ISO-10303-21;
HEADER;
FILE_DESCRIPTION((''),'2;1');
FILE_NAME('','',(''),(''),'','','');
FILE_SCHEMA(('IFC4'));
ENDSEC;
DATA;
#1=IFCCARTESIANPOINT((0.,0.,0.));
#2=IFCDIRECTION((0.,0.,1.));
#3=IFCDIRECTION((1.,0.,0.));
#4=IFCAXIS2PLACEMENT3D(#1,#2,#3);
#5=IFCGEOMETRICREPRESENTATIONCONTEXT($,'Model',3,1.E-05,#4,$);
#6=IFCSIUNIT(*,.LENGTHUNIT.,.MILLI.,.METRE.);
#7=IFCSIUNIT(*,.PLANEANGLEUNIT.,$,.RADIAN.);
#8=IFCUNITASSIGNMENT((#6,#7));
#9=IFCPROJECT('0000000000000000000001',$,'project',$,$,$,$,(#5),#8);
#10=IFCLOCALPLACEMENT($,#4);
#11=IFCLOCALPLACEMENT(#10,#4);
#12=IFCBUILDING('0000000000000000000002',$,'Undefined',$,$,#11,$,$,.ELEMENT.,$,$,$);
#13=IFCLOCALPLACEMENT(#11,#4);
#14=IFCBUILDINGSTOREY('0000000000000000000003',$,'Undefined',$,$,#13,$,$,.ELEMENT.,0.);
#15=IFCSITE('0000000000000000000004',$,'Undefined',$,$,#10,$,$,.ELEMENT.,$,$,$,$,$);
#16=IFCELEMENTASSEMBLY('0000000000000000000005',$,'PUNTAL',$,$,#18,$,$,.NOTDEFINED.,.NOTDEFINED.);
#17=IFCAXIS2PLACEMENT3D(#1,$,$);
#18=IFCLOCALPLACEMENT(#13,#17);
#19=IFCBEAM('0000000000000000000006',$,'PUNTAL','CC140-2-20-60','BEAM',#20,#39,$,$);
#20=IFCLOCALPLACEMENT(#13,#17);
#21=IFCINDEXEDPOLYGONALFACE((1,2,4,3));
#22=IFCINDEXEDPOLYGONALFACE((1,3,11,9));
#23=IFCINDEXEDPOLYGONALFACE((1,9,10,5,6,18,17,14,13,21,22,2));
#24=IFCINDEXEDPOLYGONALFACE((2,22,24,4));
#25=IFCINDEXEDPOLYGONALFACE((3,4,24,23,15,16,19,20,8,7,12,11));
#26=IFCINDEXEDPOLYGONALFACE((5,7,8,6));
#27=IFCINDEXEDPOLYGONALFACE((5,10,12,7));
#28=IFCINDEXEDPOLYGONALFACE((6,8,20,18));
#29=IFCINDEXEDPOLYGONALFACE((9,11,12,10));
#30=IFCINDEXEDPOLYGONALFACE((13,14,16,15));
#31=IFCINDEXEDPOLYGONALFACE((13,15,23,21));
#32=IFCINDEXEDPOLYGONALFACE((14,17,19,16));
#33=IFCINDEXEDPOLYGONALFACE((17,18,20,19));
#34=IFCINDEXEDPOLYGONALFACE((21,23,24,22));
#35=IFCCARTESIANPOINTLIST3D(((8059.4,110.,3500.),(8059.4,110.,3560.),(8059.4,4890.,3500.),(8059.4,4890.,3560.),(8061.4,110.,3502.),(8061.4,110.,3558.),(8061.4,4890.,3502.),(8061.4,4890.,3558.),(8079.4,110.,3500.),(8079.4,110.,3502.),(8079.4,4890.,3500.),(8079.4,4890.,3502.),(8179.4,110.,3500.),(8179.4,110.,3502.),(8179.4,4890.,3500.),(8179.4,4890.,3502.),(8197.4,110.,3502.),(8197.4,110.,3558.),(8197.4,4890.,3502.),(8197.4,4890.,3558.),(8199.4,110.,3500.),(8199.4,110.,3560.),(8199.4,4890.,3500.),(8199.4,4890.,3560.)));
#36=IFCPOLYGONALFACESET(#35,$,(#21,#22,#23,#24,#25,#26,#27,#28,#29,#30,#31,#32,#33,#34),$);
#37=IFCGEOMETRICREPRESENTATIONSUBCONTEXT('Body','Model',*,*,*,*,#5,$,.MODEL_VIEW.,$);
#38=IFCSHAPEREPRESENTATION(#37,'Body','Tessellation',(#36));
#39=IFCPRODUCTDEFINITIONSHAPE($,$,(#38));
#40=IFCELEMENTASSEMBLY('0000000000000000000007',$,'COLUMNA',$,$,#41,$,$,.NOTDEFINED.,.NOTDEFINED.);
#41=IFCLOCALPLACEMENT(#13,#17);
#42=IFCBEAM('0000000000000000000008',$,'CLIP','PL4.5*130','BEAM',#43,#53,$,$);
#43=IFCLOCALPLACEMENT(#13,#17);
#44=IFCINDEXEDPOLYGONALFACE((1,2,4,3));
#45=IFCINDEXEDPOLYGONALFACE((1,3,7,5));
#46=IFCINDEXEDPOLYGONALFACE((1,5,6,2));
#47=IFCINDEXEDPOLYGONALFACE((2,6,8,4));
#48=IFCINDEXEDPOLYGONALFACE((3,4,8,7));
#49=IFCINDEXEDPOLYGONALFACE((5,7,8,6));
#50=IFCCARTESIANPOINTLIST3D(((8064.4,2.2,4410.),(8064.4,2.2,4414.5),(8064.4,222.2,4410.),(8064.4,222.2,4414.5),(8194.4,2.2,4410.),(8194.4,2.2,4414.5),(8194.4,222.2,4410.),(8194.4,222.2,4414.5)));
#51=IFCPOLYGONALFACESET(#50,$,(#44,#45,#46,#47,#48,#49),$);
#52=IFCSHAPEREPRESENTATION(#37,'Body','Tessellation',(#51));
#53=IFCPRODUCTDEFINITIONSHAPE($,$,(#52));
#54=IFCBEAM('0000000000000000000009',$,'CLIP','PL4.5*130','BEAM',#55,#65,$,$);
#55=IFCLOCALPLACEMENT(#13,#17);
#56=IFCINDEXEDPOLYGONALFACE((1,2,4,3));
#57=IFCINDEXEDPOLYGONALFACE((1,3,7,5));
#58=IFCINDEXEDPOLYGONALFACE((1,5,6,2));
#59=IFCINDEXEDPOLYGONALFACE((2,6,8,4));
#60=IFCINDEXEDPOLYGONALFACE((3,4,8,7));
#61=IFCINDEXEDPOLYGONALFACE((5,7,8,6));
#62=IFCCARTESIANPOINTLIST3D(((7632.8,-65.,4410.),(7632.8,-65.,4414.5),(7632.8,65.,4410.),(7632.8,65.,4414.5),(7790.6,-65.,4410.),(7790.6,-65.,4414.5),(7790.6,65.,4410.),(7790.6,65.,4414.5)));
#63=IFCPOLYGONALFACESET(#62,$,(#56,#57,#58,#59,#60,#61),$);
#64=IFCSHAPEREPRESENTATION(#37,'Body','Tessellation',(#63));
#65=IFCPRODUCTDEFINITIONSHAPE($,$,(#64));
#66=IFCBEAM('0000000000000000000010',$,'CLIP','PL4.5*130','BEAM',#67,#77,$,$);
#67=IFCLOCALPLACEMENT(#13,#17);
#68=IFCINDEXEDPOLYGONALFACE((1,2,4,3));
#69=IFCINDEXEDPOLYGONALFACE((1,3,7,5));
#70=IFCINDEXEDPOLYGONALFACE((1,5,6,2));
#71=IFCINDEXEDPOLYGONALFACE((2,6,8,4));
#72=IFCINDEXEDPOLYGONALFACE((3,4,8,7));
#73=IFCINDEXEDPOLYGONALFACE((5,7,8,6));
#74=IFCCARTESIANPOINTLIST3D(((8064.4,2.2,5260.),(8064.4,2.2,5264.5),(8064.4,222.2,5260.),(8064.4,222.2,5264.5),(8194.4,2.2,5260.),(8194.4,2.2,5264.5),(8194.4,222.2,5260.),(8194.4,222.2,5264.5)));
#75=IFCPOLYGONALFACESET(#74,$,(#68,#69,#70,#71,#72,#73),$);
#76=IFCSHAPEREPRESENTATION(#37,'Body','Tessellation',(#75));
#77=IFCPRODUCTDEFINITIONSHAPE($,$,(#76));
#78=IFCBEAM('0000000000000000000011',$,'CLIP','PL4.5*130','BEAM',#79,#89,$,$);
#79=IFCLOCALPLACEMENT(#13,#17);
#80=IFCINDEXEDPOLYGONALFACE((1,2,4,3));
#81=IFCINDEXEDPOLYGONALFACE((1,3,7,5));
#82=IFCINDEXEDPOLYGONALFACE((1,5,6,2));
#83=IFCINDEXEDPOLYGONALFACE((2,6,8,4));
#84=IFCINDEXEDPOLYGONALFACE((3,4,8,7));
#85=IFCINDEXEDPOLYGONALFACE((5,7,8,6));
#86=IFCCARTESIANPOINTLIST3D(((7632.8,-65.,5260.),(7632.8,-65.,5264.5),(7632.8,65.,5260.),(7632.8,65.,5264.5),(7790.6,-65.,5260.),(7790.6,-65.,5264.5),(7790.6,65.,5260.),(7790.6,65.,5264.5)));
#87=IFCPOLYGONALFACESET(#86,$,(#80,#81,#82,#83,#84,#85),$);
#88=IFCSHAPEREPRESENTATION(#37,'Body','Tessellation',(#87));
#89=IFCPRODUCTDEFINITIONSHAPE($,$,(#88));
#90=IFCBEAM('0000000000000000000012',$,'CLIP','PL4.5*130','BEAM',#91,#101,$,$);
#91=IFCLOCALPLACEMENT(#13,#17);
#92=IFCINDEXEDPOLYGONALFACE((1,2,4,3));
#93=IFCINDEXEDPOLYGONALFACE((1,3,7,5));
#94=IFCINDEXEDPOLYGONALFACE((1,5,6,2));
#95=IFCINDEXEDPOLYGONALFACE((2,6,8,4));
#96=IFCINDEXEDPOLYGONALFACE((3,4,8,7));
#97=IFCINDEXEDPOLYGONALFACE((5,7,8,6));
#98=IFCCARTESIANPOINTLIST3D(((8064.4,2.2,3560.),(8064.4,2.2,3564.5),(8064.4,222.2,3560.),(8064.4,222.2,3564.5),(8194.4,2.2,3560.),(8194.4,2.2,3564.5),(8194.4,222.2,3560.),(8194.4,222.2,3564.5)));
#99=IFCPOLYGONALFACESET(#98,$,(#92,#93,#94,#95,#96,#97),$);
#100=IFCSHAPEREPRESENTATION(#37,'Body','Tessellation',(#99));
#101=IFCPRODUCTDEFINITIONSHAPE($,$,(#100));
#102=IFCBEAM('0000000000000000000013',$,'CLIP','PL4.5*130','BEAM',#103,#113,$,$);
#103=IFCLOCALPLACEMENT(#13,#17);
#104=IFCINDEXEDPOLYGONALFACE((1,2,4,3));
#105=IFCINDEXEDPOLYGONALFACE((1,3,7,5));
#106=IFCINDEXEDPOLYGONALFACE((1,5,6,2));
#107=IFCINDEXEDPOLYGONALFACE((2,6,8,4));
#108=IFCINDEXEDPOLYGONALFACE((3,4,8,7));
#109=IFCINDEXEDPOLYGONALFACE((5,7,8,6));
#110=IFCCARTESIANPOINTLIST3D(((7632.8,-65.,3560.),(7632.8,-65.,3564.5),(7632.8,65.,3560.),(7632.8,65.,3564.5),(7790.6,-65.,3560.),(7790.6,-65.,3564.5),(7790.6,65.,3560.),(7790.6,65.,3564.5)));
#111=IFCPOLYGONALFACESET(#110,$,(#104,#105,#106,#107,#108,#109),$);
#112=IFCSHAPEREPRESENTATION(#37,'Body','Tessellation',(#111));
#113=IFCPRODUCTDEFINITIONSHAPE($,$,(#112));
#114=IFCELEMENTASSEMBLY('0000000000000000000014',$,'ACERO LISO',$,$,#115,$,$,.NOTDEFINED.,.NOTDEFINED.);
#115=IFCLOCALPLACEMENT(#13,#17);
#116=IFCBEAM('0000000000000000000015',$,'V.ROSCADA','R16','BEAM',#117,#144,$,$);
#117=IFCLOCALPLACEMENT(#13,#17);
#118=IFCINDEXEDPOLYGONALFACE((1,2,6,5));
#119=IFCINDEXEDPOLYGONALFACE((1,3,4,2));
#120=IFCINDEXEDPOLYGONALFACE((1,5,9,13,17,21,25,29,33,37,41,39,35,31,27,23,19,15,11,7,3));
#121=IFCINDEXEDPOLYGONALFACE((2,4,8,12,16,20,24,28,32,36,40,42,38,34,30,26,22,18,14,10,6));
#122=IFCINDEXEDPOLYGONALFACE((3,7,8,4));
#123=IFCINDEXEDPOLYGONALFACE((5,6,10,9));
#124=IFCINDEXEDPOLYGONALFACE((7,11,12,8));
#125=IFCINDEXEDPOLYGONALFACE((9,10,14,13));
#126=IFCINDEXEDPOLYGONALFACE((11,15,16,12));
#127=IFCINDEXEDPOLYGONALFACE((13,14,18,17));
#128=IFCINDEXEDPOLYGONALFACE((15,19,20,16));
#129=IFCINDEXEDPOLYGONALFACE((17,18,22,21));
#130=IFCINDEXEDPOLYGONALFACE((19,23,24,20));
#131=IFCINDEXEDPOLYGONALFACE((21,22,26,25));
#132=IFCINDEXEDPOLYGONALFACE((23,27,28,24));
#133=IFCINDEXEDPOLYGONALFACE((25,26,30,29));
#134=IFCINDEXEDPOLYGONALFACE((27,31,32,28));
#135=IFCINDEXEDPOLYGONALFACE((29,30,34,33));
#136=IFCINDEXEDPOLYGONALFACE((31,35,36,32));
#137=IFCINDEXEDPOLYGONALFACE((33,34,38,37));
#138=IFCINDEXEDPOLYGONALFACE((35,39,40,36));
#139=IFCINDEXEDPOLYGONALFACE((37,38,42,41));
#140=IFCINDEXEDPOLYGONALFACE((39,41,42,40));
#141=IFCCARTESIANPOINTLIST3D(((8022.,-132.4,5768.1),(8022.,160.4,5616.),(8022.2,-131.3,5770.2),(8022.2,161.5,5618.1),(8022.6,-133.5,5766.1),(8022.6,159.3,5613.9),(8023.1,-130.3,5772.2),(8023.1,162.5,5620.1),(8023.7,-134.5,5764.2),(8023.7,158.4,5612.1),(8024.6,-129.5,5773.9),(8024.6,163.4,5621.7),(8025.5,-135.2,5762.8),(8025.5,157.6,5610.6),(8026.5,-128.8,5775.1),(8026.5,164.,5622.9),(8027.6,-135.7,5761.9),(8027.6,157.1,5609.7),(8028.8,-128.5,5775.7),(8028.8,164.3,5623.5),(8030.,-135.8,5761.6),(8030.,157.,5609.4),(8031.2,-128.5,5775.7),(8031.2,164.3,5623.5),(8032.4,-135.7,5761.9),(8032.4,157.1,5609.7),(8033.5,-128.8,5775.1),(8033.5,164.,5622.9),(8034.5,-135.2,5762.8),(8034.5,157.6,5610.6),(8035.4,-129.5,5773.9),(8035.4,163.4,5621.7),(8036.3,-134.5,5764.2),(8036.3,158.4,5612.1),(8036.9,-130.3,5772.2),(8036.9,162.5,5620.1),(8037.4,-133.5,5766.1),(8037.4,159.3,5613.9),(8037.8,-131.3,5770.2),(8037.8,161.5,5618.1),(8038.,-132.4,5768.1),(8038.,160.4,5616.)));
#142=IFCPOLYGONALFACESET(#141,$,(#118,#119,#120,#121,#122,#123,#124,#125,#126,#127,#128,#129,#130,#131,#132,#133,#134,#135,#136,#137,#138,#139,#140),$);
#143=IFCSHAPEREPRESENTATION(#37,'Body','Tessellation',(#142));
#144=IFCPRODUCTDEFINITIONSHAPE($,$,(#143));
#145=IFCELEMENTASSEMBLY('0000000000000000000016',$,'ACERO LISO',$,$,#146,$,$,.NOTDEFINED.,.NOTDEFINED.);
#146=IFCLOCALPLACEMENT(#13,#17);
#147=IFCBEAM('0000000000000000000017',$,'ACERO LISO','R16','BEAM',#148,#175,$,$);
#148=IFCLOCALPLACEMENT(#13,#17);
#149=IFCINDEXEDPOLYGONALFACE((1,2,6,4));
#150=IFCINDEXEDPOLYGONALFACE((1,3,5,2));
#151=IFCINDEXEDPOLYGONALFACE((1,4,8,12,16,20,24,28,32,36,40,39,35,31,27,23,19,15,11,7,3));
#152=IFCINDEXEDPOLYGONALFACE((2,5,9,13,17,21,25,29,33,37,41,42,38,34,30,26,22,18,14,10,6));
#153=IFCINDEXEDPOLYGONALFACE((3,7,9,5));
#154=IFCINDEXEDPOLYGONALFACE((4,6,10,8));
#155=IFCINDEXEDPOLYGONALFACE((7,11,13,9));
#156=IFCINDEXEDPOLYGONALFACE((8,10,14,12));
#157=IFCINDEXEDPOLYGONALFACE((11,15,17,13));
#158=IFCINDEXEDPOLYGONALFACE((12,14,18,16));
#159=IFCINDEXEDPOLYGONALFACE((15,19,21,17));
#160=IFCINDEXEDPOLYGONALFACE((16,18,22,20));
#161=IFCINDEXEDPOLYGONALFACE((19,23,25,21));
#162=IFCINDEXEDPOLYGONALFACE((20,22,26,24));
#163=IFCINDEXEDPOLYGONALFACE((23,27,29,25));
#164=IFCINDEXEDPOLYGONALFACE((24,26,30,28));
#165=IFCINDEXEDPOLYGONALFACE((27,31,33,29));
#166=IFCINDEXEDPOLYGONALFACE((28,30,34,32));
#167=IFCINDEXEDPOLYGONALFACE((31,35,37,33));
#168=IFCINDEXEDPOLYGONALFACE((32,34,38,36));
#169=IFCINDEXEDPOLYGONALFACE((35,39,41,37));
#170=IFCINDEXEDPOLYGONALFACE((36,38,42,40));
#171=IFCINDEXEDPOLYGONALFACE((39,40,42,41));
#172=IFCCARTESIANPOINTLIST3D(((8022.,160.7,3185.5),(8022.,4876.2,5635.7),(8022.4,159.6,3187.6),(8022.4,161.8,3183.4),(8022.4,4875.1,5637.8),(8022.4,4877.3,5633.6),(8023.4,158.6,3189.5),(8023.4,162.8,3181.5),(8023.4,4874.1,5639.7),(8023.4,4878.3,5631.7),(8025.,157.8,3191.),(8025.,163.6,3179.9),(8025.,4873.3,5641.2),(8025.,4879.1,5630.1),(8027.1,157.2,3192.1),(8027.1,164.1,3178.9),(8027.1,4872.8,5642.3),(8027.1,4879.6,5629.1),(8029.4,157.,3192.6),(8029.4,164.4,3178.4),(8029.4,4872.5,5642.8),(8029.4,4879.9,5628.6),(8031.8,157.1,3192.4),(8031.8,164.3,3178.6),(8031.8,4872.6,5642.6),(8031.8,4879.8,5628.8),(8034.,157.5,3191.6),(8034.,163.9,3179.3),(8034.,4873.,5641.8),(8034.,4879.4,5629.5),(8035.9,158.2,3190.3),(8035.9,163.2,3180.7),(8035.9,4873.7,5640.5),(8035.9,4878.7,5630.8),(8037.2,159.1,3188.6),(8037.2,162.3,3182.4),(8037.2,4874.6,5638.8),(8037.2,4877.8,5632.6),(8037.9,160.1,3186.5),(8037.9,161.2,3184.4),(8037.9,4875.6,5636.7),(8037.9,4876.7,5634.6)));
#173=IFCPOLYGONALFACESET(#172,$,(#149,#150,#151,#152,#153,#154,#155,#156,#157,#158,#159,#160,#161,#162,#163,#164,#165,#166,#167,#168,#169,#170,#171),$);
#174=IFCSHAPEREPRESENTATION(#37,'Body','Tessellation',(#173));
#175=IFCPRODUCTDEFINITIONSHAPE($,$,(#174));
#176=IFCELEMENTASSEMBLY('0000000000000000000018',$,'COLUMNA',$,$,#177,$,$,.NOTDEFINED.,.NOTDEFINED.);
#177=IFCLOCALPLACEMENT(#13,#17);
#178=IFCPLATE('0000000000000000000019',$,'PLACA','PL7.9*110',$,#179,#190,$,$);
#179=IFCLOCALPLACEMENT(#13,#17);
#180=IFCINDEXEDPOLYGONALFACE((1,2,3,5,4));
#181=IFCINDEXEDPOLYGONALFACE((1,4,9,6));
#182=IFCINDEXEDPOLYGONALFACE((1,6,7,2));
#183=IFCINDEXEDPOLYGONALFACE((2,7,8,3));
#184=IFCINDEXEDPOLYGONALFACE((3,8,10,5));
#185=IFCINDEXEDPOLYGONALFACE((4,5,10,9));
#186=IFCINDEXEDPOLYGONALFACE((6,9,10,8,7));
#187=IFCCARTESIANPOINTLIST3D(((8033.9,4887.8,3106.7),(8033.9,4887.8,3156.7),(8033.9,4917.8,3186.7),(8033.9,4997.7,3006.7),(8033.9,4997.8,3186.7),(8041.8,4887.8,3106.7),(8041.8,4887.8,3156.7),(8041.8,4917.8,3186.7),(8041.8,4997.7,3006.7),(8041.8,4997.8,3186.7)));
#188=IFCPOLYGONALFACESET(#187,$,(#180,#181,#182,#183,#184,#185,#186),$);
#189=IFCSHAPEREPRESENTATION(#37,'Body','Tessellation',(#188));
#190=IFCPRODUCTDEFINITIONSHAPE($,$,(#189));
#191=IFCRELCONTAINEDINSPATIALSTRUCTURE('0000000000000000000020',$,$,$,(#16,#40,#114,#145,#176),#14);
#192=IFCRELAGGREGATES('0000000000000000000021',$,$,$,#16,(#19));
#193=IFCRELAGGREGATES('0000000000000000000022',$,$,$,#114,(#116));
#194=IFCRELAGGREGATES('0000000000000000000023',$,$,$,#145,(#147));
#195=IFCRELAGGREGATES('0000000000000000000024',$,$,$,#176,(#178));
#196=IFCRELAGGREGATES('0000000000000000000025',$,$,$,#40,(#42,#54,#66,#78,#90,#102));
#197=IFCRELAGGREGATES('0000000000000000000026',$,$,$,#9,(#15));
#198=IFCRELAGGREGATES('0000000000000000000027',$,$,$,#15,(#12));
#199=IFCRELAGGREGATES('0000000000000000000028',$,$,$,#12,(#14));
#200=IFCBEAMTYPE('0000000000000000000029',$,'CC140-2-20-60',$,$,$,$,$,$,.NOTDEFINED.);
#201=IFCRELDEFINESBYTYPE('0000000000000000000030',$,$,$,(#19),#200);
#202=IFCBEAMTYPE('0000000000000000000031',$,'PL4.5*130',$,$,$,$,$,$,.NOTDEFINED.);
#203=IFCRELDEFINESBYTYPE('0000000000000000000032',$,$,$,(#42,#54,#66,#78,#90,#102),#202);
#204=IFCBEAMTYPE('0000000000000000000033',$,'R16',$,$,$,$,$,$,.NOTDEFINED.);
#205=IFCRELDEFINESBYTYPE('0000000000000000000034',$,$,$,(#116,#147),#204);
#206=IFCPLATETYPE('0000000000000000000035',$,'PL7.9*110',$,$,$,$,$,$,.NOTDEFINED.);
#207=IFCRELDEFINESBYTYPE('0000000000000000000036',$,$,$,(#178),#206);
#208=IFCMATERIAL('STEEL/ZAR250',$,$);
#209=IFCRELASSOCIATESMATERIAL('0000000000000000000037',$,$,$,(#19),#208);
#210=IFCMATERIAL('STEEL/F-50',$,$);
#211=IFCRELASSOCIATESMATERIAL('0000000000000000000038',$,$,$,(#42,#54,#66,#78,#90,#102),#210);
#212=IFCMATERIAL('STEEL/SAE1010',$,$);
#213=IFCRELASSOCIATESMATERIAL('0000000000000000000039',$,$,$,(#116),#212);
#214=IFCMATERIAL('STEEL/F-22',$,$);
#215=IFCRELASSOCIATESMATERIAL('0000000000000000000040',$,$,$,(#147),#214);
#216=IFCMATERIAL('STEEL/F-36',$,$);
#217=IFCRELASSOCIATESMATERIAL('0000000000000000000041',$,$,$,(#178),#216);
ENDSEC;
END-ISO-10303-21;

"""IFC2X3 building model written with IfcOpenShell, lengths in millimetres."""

from ifc_helpers import new_model, si_unit, frame, origin_with_axes, origin_2d_with_axis, place, context, subcontext, project, spatial, polyline, rectangle, circle, c_section, outline, extrude, clip, halfspace, material, type_object, element, aggregate, save


model = new_model("IFC2X3")

# Units and contexts
model_context = context("Model", 3, precision=1e-05, world=origin_with_axes())
body_context = subcontext(model_context, "Body", "Model", "MODEL_VIEW")
ifc_project = project(units=[si_unit("LENGTHUNIT", "METRE", prefix="MILLI"), si_unit("PLANEANGLEUNIT", "RADIAN")], contexts=[model_context])

# Site, building, storey
site_placement = place(None, origin_with_axes())
site = spatial("IfcSite", under=ifc_project, at=site_placement, Name="Undefined", CompositionType="ELEMENT")
building_placement = place(site_placement, origin_with_axes())
building = spatial("IfcBuilding", under=site, at=building_placement, Name="Undefined", CompositionType="ELEMENT")
storey_placement = place(building_placement, origin_with_axes())
storey = spatial("IfcBuildingStorey", under=building, at=storey_placement, Name="Undefined", CompositionType="ELEMENT", Elevation=0.0)

# Element assembly, beam
assembly_1_placement = place(storey_placement, origin_with_axes())
assembly_1 = element("IfcElementAssembly", 1, at=assembly_1_placement, inside=storey, Name="PUNTAL", AssemblyPlace="NOTDEFINED", PredefinedType="NOTDEFINED")
ifc_material_1 = material(Name="STEEL/ZAR250")
beam_type_1 = type_object("IfcBeamType", Name="CC140-2-20-60", PredefinedType="NOTDEFINED")
beam_1_placement = place(assembly_1_placement, frame((8129.4, 4890.0, 3530.0), z_axis=(-1.0, 0.0, 0.0), x_axis=(0.0, -1.0, 0.0)))
beam_1 = element("IfcBeam", 2, at=beam_1_placement, type_object=beam_type_1, material=ifc_material_1, Name="PUNTAL", Description="CC140-2-20-60", ObjectType="BEAM", context=body_context, shape_type="SweptSolid", body=[
    extrude(c_section(Depth=140.0, Width=60.0, WallThickness=2.0, Girth=20.0, at=origin_2d_with_axis()), frame((4780.0, 0.0, 0.0), z_axis=(-1.0, 0.0, 0.0), x_axis=(0.0, -1.0, 0.0)), (0.0, 0.0, 1.0), 4780.0),
])
aggregate(assembly_1, [beam_1])

# Element assembly, beams
assembly_2_placement = place(storey_placement, origin_with_axes())
assembly_2 = element("IfcElementAssembly", 3, at=assembly_2_placement, inside=storey, Name="COLUMNA", AssemblyPlace="NOTDEFINED", PredefinedType="NOTDEFINED")
ifc_material_2 = material(Name="STEEL/F-50")
beam_type_2 = type_object("IfcBeamType", Name="PL4.5*130", PredefinedType="NOTDEFINED")
beam_2_placement = place(assembly_2_placement, frame((8129.4, 2.2, 4412.2), z_axis=(-1.0, 0.000006, 0.0), x_axis=(0.000006, 1.0, 0.0)))
beam_2 = element("IfcBeam", 4, at=beam_2_placement, type_object=beam_type_2, material=ifc_material_2, Name="CLIP", Description="PL4.5*130", ObjectType="BEAM", context=body_context, shape_type="SweptSolid", body=[
    extrude(rectangle(XDim=4.5, YDim=130.0, at=origin_2d_with_axis()), frame((220.0, 0.0, 0.0), z_axis=(-1.0, 0.0, 0.0), x_axis=(0.0, -1.0, 0.0)), (0.0, 0.0, 1.0), 220.0),
])
beam_3_placement = place(assembly_2_placement, frame((7790.6, 0.0, 4412.2), z_axis=(-0.000008, -1.0, 0.0), x_axis=(-1.0, 0.000009, 0.0)))
beam_3 = element("IfcBeam", 5, at=beam_3_placement, type_object=beam_type_2, material=ifc_material_2, Name="CLIP", Description="PL4.5*130", ObjectType="BEAM", context=body_context, shape_type="SweptSolid", body=[
    extrude(rectangle(XDim=4.5, YDim=130.0, at=origin_2d_with_axis()), frame((157.9, 0.0, 0.0), z_axis=(-1.0, 0.0, 0.0), x_axis=(0.0, -1.0, 0.0)), (0.0, 0.0, 1.0), 157.8),
])
beam_4_placement = place(assembly_2_placement, frame((8129.4, 2.2, 5262.2), z_axis=(-1.0, 0.000006, 0.0), x_axis=(0.000006, 1.0, 0.0)))
beam_4 = element("IfcBeam", 6, at=beam_4_placement, type_object=beam_type_2, material=ifc_material_2, Name="CLIP", Description="PL4.5*130", ObjectType="BEAM", context=body_context, shape_type="SweptSolid", body=[
    extrude(rectangle(XDim=4.5, YDim=130.0, at=origin_2d_with_axis()), frame((220.0, 0.0, 0.0), z_axis=(-1.0, 0.0, 0.0), x_axis=(0.0, -1.0, 0.0)), (0.0, 0.0, 1.0), 220.0),
])
beam_5_placement = place(assembly_2_placement, frame((7790.6, 0.0, 5262.2), z_axis=(-0.000008, -1.0, 0.0), x_axis=(-1.0, 0.000009, 0.0)))
beam_5 = element("IfcBeam", 7, at=beam_5_placement, type_object=beam_type_2, material=ifc_material_2, Name="CLIP", Description="PL4.5*130", ObjectType="BEAM", context=body_context, shape_type="SweptSolid", body=[
    extrude(rectangle(XDim=4.5, YDim=130.0, at=origin_2d_with_axis()), frame((157.9, 0.0, 0.0), z_axis=(-1.0, 0.0, 0.0), x_axis=(0.0, -1.0, 0.0)), (0.0, 0.0, 1.0), 157.8),
])
beam_6_placement = place(assembly_2_placement, frame((8129.4, 2.2, 3562.2), z_axis=(-1.0, 0.000006, 0.0), x_axis=(0.000006, 1.0, 0.0)))
beam_6 = element("IfcBeam", 8, at=beam_6_placement, type_object=beam_type_2, material=ifc_material_2, Name="CLIP", Description="PL4.5*130", ObjectType="BEAM", context=body_context, shape_type="SweptSolid", body=[
    extrude(rectangle(XDim=4.5, YDim=130.0, at=origin_2d_with_axis()), frame((220.0, 0.0, 0.0), z_axis=(-1.0, 0.0, 0.0), x_axis=(0.0, -1.0, 0.0)), (0.0, 0.0, 1.0), 220.0),
])
beam_7_placement = place(assembly_2_placement, frame((7790.6, 0.0, 3562.2), z_axis=(-0.000008, -1.0, 0.0), x_axis=(-1.0, 0.000009, 0.0)))
beam_7 = element("IfcBeam", 9, at=beam_7_placement, type_object=beam_type_2, material=ifc_material_2, Name="CLIP", Description="PL4.5*130", ObjectType="BEAM", context=body_context, shape_type="SweptSolid", body=[
    extrude(rectangle(XDim=4.5, YDim=130.0, at=origin_2d_with_axis()), frame((157.9, 0.0, 0.0), z_axis=(-1.0, 0.0, 0.0), x_axis=(0.0, -1.0, 0.0)), (0.0, 0.0, 1.0), 157.8),
])

# Element assemblies, beams
assembly_3_placement = place(storey_placement, origin_with_axes())
assembly_3 = element("IfcElementAssembly", 10, at=assembly_3_placement, inside=storey, Name="ACERO LISO", AssemblyPlace="NOTDEFINED", PredefinedType="NOTDEFINED")
ifc_material_3 = material(Name="STEEL/SAE1010")
beam_type_3 = type_object("IfcBeamType", Name="R16", PredefinedType="NOTDEFINED")
beam_8_placement = place(assembly_3_placement, frame((8030.0, 160.7, 5616.5), z_axis=(-1.0, 0.0, 0.0), x_axis=(0.0, -0.887362, 0.461073)))
beam_8 = element("IfcBeam", 11, at=beam_8_placement, type_object=beam_type_3, material=ifc_material_3, Name="V.ROSCADA", Description="R16", ObjectType="BEAM", context=body_context, shape_type="SweptSolid", body=[
    extrude(circle(Radius=8.0, at=origin_2d_with_axis()), frame((330.0, 0.0, 0.0), z_axis=(-1.0, 0.0, 0.0), x_axis=(0.0, -1.0, 0.0)), (0.0, 0.0, 1.0), 330.0),
])
aggregate(assembly_3, [beam_8])
assembly_4_placement = place(storey_placement, origin_with_axes())
assembly_4 = element("IfcElementAssembly", 12, at=assembly_4_placement, inside=storey, Name="ACERO LISO", AssemblyPlace="NOTDEFINED", PredefinedType="NOTDEFINED")
ifc_material_4 = material(Name="STEEL/F-22")
beam_9_placement = place(assembly_4_placement, frame((8030.0, 160.7, 3185.5), z_axis=(0.0, 0.461073, -0.887362), x_axis=(0.0, 0.887362, 0.461073)))
beam_9 = element("IfcBeam", 13, at=beam_9_placement, type_object=beam_type_3, material=ifc_material_4, Name="ACERO LISO", Description="R16", ObjectType="BEAM", context=body_context, shape_type="Clipping", body=[
    clip(extrude(circle(Radius=8.0, at=origin_2d_with_axis()), frame((5453.6, 0.0, 0.0), z_axis=(-1.0, 0.0, 0.0), x_axis=(0.0, -1.0, 0.0)), (0.0, 0.0, 1.0), 5453.6), halfspace(frame((5314.1, 0.0, 0.0), z_axis=(-1.0, 0.0, 0.0), x_axis=(0.0, 1.0, 0.0)), True)),
])
aggregate(assembly_4, [beam_9])
ifc_material_5 = material(Name="STEEL/F-36")

# Element assembly, plate
assembly_5_placement = place(storey_placement, origin_with_axes())
assembly_5 = element("IfcElementAssembly", 14, at=assembly_5_placement, inside=storey, Name="COLUMNA", AssemblyPlace="NOTDEFINED", PredefinedType="NOTDEFINED")
plate_type_1 = type_object("IfcPlateType", Name="PL7.9*110", PredefinedType="NOTDEFINED")
plate_1_placement = place(assembly_5_placement, frame((8037.9, 4887.8, 3106.7), z_axis=(1.0, 0.0, 0.0), x_axis=(0.0, 0.73994, -0.672673)))
plate_1 = element("IfcPlate", 15, at=plate_1_placement, type_object=plate_type_1, material=ifc_material_5, Name="PLACA", Description="PL7.9*110", context=body_context, shape_type="SweptSolid", body=[
    extrude(outline(polyline([(0.0, 0.0), (148.7, 0.0), (27.6, 133.2), (-31.6, 79.4), (-33.6, 37.0), (0.0, 0.0)])), frame((0.0, 0.0, -4.0), z_axis=(0.0, 0.0, 1.0), x_axis=(1.0, 0.0, 0.0)), (0.0, 0.0, 1.0), 7.9),
])
aggregate(assembly_5, [plate_1])

aggregate(assembly_2, [beam_2, beam_3, beam_4, beam_5, beam_6, beam_7])

save(model, "model.ifc")
